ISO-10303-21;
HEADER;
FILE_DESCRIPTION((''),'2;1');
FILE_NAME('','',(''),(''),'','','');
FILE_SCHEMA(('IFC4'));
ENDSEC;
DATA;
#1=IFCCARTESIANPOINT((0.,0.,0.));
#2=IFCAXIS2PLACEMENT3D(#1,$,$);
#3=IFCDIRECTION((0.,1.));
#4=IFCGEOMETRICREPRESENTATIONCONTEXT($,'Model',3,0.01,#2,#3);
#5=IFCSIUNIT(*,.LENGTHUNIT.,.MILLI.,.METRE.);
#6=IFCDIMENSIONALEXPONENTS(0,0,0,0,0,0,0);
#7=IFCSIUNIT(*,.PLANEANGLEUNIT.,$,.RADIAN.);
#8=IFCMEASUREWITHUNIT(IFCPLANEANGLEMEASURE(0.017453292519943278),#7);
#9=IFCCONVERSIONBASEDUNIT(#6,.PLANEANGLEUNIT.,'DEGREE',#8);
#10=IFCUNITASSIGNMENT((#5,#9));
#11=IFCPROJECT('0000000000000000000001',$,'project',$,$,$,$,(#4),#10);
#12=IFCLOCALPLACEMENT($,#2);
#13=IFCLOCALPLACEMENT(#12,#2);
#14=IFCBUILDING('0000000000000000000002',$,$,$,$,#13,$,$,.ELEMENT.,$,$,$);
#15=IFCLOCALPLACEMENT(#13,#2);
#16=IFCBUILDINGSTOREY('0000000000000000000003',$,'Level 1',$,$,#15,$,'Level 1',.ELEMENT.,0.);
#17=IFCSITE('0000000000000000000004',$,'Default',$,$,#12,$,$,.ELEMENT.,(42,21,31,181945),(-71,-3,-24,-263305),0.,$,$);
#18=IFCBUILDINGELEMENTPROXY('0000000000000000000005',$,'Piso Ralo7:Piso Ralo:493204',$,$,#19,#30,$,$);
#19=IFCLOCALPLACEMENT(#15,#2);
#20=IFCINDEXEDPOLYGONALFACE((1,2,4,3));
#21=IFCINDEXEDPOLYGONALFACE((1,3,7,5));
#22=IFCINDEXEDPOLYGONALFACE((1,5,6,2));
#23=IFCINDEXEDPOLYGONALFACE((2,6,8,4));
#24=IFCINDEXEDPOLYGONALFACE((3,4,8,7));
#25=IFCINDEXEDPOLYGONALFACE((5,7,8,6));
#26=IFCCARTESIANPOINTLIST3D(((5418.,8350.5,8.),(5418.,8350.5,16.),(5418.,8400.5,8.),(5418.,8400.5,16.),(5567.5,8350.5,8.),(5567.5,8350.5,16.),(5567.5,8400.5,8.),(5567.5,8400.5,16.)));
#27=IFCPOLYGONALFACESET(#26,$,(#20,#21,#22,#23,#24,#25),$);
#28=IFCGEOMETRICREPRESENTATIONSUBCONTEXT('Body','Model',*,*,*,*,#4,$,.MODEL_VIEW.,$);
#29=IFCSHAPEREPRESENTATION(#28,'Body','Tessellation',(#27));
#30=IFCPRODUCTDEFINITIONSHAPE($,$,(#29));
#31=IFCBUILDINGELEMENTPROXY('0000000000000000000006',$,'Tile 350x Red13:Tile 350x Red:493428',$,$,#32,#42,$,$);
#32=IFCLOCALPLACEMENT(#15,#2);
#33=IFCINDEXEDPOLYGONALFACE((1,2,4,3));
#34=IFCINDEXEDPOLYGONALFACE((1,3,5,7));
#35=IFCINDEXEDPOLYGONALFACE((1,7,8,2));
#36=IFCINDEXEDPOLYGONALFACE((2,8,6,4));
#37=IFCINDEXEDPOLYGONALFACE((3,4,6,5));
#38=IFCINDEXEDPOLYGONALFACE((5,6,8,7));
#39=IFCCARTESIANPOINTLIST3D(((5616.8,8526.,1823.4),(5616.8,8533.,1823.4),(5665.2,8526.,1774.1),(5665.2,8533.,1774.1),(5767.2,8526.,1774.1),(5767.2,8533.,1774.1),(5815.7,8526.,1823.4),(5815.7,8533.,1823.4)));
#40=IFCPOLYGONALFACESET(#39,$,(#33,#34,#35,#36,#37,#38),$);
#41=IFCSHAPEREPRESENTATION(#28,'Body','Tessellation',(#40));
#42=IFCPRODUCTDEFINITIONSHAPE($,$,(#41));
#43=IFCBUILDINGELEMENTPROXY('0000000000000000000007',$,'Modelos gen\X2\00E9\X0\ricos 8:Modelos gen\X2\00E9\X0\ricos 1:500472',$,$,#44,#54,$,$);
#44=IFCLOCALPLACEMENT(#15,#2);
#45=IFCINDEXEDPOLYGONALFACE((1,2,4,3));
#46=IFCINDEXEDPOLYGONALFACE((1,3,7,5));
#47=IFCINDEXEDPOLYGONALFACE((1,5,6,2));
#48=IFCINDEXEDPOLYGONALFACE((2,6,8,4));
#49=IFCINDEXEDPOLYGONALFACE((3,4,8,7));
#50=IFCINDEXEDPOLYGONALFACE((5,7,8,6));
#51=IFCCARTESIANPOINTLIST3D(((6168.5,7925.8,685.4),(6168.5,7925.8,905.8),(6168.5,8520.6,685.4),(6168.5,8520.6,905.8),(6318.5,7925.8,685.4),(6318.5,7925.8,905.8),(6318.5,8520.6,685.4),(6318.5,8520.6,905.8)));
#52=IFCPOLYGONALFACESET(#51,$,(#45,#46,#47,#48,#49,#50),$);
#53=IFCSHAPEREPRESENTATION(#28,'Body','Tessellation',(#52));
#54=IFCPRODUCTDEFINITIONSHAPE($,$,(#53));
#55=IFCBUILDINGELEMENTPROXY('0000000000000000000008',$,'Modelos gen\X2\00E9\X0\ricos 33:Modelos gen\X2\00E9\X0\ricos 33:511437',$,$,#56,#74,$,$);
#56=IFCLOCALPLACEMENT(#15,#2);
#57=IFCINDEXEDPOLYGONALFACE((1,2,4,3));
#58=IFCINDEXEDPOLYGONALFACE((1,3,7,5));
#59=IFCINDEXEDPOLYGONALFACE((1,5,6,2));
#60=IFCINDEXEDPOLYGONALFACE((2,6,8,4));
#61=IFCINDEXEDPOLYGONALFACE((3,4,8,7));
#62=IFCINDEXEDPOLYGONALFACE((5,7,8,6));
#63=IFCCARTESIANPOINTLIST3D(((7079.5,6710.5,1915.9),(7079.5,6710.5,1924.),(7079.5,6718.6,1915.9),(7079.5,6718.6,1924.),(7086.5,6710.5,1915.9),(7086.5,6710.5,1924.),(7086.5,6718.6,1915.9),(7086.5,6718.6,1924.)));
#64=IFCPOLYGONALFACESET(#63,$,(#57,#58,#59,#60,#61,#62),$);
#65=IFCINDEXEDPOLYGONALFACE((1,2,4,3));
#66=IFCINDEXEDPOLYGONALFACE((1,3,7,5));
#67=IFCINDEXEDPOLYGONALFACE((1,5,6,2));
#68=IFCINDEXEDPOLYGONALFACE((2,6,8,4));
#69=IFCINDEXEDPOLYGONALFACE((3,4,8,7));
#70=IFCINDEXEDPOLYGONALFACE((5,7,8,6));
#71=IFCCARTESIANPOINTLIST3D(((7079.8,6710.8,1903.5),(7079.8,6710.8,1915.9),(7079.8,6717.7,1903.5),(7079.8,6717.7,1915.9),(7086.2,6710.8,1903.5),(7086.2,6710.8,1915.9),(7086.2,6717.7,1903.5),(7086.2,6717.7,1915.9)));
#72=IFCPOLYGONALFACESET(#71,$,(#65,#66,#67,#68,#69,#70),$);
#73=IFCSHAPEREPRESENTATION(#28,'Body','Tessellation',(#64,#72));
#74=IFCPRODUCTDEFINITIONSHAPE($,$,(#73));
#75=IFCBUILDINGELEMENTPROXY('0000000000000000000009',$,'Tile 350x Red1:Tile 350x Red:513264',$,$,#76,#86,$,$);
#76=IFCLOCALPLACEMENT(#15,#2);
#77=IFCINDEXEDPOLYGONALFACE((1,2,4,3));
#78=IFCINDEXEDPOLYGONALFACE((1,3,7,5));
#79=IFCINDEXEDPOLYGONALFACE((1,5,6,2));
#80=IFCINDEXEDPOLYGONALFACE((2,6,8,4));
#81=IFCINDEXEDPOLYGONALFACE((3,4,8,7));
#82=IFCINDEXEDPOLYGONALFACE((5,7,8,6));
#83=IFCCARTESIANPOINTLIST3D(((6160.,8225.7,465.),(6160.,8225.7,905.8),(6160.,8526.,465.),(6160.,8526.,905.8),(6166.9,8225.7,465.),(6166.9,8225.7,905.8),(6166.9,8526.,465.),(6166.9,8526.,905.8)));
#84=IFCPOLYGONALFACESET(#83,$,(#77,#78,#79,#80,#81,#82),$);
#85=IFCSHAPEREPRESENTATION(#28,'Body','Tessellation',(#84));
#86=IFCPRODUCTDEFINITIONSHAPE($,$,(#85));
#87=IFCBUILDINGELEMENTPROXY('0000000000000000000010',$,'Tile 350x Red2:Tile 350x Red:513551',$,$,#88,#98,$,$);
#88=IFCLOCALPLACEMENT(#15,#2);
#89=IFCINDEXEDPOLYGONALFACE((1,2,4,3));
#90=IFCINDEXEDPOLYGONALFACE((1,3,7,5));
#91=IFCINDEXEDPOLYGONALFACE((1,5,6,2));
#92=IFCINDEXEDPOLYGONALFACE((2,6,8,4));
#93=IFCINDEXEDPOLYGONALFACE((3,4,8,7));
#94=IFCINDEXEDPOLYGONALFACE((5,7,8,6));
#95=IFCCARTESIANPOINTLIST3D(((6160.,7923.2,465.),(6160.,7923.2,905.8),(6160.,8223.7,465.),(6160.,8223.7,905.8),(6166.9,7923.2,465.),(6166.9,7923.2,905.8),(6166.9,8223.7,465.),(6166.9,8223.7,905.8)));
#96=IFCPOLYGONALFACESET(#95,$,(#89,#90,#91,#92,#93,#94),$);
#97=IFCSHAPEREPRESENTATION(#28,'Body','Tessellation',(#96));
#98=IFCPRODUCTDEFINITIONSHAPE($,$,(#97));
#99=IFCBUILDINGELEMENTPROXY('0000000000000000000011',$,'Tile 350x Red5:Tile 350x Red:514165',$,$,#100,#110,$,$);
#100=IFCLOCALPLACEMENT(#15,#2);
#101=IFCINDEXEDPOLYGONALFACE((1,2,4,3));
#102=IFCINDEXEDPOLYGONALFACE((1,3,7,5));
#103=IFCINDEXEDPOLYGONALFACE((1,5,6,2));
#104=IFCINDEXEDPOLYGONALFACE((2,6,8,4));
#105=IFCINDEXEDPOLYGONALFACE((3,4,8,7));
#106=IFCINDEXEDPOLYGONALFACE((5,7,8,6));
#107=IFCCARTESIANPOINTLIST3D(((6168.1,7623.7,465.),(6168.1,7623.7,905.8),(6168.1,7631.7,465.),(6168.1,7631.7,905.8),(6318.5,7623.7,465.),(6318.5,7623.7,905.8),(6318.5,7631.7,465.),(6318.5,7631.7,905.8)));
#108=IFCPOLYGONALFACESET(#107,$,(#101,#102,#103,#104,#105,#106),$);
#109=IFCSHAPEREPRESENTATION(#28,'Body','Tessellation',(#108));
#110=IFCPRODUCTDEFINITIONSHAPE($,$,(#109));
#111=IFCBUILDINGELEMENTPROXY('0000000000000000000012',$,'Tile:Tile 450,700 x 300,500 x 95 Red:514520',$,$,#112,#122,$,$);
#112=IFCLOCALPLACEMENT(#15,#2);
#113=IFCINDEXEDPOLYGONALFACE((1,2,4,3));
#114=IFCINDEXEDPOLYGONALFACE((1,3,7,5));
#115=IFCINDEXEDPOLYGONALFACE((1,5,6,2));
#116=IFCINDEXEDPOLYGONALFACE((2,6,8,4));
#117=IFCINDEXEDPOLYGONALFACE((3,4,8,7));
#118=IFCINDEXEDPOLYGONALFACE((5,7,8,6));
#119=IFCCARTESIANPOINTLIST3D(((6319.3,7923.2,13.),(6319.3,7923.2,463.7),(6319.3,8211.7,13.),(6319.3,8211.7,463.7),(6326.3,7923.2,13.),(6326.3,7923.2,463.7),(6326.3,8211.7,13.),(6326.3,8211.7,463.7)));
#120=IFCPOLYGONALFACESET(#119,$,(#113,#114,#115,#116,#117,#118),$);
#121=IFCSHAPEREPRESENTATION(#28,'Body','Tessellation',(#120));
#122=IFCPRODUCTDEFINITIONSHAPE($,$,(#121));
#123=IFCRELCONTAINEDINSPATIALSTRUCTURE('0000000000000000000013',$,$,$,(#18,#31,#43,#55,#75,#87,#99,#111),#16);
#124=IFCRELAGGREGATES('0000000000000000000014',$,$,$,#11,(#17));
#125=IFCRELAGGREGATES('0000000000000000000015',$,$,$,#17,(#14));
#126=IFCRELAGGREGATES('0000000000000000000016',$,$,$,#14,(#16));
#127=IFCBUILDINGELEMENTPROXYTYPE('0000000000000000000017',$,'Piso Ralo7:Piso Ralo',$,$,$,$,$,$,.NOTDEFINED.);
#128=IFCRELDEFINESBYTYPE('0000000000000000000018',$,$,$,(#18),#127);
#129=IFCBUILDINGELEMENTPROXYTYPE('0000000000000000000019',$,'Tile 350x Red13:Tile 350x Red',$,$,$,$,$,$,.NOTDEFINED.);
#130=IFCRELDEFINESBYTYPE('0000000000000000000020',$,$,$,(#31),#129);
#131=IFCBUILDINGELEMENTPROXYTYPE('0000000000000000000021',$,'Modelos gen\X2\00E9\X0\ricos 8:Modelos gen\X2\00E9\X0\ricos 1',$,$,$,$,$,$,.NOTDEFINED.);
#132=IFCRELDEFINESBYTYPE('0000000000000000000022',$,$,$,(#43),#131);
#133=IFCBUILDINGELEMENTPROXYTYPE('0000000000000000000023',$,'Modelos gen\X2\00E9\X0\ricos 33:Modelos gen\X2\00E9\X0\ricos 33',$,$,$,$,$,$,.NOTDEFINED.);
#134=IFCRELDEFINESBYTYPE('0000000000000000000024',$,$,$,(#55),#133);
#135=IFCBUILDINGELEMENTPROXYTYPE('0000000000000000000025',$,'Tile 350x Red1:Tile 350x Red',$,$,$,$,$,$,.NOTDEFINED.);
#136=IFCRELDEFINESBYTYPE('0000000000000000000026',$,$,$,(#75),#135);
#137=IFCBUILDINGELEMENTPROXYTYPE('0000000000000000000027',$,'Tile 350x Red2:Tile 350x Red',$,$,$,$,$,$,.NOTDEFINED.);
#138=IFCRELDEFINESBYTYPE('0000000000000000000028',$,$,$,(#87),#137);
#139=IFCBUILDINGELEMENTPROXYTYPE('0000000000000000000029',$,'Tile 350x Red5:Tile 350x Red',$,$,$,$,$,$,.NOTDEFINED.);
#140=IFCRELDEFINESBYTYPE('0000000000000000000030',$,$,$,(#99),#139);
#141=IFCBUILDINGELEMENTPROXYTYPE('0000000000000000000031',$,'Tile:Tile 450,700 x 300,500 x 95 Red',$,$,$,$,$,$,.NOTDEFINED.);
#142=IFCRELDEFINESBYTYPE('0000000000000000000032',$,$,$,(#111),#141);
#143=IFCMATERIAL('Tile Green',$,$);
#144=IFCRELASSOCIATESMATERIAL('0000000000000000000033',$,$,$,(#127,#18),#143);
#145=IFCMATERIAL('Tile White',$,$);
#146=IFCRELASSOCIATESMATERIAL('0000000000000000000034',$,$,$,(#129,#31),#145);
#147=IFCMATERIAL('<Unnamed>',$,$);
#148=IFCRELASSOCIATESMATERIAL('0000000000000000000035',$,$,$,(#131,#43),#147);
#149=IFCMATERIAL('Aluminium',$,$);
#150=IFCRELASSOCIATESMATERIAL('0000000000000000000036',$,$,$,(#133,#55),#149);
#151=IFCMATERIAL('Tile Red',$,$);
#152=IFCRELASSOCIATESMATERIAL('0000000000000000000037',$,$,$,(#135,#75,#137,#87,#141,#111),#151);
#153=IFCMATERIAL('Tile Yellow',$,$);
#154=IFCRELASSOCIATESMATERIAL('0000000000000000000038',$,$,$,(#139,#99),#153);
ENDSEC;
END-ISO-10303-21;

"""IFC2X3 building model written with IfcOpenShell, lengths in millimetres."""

from ifc_helpers import new_model, entity, si_unit, converted_unit, direction, frame, frame_2d, origin, origin_2d_with_axis, place, context, subcontext, project, spatial, polyline, rectangle, outline, extrude, source, transform, mapped, material, type_object, type_shapes, element, save


model = new_model("IFC2X3")

# Units and contexts
model_context = context("Model", 3, precision=0.01, world=origin(), true_north=direction((0.0, 1.0)))
body_context = subcontext(model_context, "Body", "Model", "MODEL_VIEW")
ifc_project = project(units=[si_unit("LENGTHUNIT", "METRE", prefix="MILLI"), converted_unit("PLANEANGLEUNIT", "DEGREE", entity("IfcPlaneAngleMeasure", 0.017453292519943278), si_unit("PLANEANGLEUNIT", "RADIAN"), dimensions=[0, 0, 0, 0, 0, 0, 0])], contexts=[model_context])

# Site, building, storey
site_placement = place(None, origin())
site = spatial("IfcSite", under=ifc_project, at=site_placement, Name="Default", CompositionType="ELEMENT", RefLatitude=(42, 21, 31, 181945), RefLongitude=(-71, -3, -24, -263305), RefElevation=0.0)
building_placement = place(site_placement, origin())
building = spatial("IfcBuilding", under=site, at=building_placement, CompositionType="ELEMENT")
storey_placement = place(building_placement, origin())
storey = spatial("IfcBuildingStorey", under=building, at=storey_placement, Name="Level 1", LongName="Level 1", CompositionType="ELEMENT", Elevation=0.0)

# Building element proxies
ifc_material_1 = material(Name="Tile Green")
building_element_proxy_type_1 = type_object("IfcBuildingElementProxyType", Name="Piso Ralo7:Piso Ralo", PredefinedType="NOTDEFINED", material=ifc_material_1)
shared_shape_1 = source(origin(), body_context, "Body", "SweptSolid", [
    extrude(rectangle(XDim=149.5, YDim=50.0, at=frame_2d((0.0, 0.0), x_axis=(1.0, 0.0))), frame((5492.7, 8375.5, 8.0), z_axis=(0.0, 0.0, 1.0), x_axis=(-1.0, 0.0, 0.0)), (0.0, 0.0, 1.0), 8.0),
])
type_shapes(building_element_proxy_type_1, [shared_shape_1])
proxy_1_placement = place(storey_placement, origin())
element("IfcBuildingElementProxy", 1, at=proxy_1_placement, inside=storey, type_object=building_element_proxy_type_1, material=ifc_material_1, Name="Piso Ralo7:Piso Ralo:493204", context=body_context, shape_type="MappedRepresentation", body=[
    mapped(shared_shape_1, transform((0.0, 0.0, 0.0), scale=1.0)),
])
ifc_material_2 = material(Name="Tile Red")
ifc_material_3 = material(Name="Tile White")
building_element_proxy_type_2 = type_object("IfcBuildingElementProxyType", Name="Tile 350x Red13:Tile 350x Red", PredefinedType="NOTDEFINED", material=ifc_material_3)
shared_shape_2 = source(origin(), body_context, "Body", "SweptSolid", [
    extrude(outline(polyline([(-99.4, -24.7), (99.4, -24.7), (51.0, 24.7), (-51.0, 24.7), (-99.4, -24.7)])), frame((5716.2, 8526.0, 1798.7), z_axis=(0.0, 1.0, 0.0), x_axis=(1.0, 0.0, 0.0)), (0.0, 0.0, 1.0), 7.0),
])
type_shapes(building_element_proxy_type_2, [shared_shape_2])
proxy_2_placement = place(storey_placement, origin())
element("IfcBuildingElementProxy", 2, at=proxy_2_placement, inside=storey, type_object=building_element_proxy_type_2, material=ifc_material_3, Name="Tile 350x Red13:Tile 350x Red:493428", context=body_context, shape_type="MappedRepresentation", body=[
    mapped(shared_shape_2, transform((0.0, 0.0, 0.0), scale=1.0)),
])
ifc_material_4 = material(Name="<Unnamed>")
building_element_proxy_type_3 = type_object("IfcBuildingElementProxyType", Name="Modelos genéricos 8:Modelos genéricos 1", PredefinedType="NOTDEFINED", material=ifc_material_4)
shared_shape_3 = source(origin(), body_context, "Body", "SweptSolid", [
    extrude(rectangle(XDim=594.8, YDim=150.0, at=origin_2d_with_axis()), frame((6243.5, 8223.2, 685.4), z_axis=(0.0, 0.0, 1.0), x_axis=(0.0, 1.0, 0.0)), (0.0, 0.0, 1.0), 220.4),
])
type_shapes(building_element_proxy_type_3, [shared_shape_3])
proxy_3_placement = place(storey_placement, origin())
element("IfcBuildingElementProxy", 3, at=proxy_3_placement, inside=storey, type_object=building_element_proxy_type_3, material=ifc_material_4, Name="Modelos genéricos 8:Modelos genéricos 1:500472", context=body_context, shape_type="MappedRepresentation", body=[
    mapped(shared_shape_3, transform((0.0, 0.0, 0.0), scale=1.0)),
])
ifc_material_5 = material(Name="Aluminium")
building_element_proxy_type_4 = type_object("IfcBuildingElementProxyType", Name="Modelos genéricos 33:Modelos genéricos 33", PredefinedType="NOTDEFINED", material=ifc_material_5)
shared_shape_4 = source(origin(), body_context, "Body", "SweptSolid", [
    extrude(rectangle(XDim=8.2, YDim=7.0, at=frame_2d((0.0, 0.0), x_axis=(1.0, 0.0))), frame((7083.0, 6714.5, 1915.9), z_axis=(0.0, 0.0, 1.0), x_axis=(0.0, 1.0, 0.0)), (0.0, 0.0, 1.0), 8.1),
    extrude(rectangle(XDim=6.9, YDim=6.4, at=frame_2d((0.0, 0.0), x_axis=(1.0, 0.0))), frame((7083.0, 6714.2, 1903.5), z_axis=(0.0, 0.0, 1.0), x_axis=(0.0, 1.0, 0.0)), (0.0, 0.0, 1.0), 12.3),
])
type_shapes(building_element_proxy_type_4, [shared_shape_4])
proxy_4_placement = place(storey_placement, origin())
element("IfcBuildingElementProxy", 4, at=proxy_4_placement, inside=storey, type_object=building_element_proxy_type_4, material=ifc_material_5, Name="Modelos genéricos 33:Modelos genéricos 33:511437", context=body_context, shape_type="MappedRepresentation", body=[
    mapped(shared_shape_4, transform((0.0, 0.0, 0.0), scale=1.0)),
])
building_element_proxy_type_5 = type_object("IfcBuildingElementProxyType", Name="Tile 350x Red1:Tile 350x Red", PredefinedType="NOTDEFINED", material=ifc_material_2)
shared_shape_5 = source(origin(), body_context, "Body", "SweptSolid", [
    extrude(rectangle(XDim=6.9, YDim=300.3, at=frame_2d((0.0, 0.0), x_axis=(1.0, 0.0))), frame((6163.4, 8375.9, 465.0), z_axis=(0.0, 0.0, 1.0), x_axis=(-1.0, 0.0, 0.0)), (0.0, 0.0, 1.0), 440.8),
])
type_shapes(building_element_proxy_type_5, [shared_shape_5])
proxy_5_placement = place(storey_placement, origin())
element("IfcBuildingElementProxy", 5, at=proxy_5_placement, inside=storey, type_object=building_element_proxy_type_5, material=ifc_material_2, Name="Tile 350x Red1:Tile 350x Red:513264", context=body_context, shape_type="MappedRepresentation", body=[
    mapped(shared_shape_5, transform((0.0, 0.0, 0.0), scale=1.0)),
])
building_element_proxy_type_6 = type_object("IfcBuildingElementProxyType", Name="Tile 350x Red2:Tile 350x Red", PredefinedType="NOTDEFINED", material=ifc_material_2)
shared_shape_6 = source(origin(), body_context, "Body", "SweptSolid", [
    extrude(rectangle(XDim=6.9, YDim=300.5, at=frame_2d((0.0, 0.0), x_axis=(1.0, 0.0))), frame((6163.4, 8073.4, 465.0), z_axis=(0.0, 0.0, 1.0), x_axis=(-1.0, 0.0, 0.0)), (0.0, 0.0, 1.0), 440.8),
])
type_shapes(building_element_proxy_type_6, [shared_shape_6])
proxy_6_placement = place(storey_placement, origin())
element("IfcBuildingElementProxy", 6, at=proxy_6_placement, inside=storey, type_object=building_element_proxy_type_6, material=ifc_material_2, Name="Tile 350x Red2:Tile 350x Red:513551", context=body_context, shape_type="MappedRepresentation", body=[
    mapped(shared_shape_6, transform((0.0, 0.0, 0.0), scale=1.0)),
])
ifc_material_6 = material(Name="Tile Yellow")
building_element_proxy_type_7 = type_object("IfcBuildingElementProxyType", Name="Tile 350x Red5:Tile 350x Red", PredefinedType="NOTDEFINED", material=ifc_material_6)
shared_shape_7 = source(origin(), body_context, "Body", "SweptSolid", [
    extrude(rectangle(XDim=8.0, YDim=150.5, at=frame_2d((0.0, 0.0), x_axis=(1.0, 0.0))), frame((6243.3, 7627.7, 465.0), z_axis=(0.0, 0.0, 1.0), x_axis=(0.0, -1.0, 0.0)), (0.0, 0.0, 1.0), 440.8),
])
type_shapes(building_element_proxy_type_7, [shared_shape_7])
proxy_7_placement = place(storey_placement, origin())
element("IfcBuildingElementProxy", 7, at=proxy_7_placement, inside=storey, type_object=building_element_proxy_type_7, material=ifc_material_6, Name="Tile 350x Red5:Tile 350x Red:514165", context=body_context, shape_type="MappedRepresentation", body=[
    mapped(shared_shape_7, transform((0.0, 0.0, 0.0), scale=1.0)),
])
building_element_proxy_type_8 = type_object("IfcBuildingElementProxyType", Name="Tile:Tile 450,700 x 300,500 x 95 Red", PredefinedType="NOTDEFINED", material=ifc_material_2)
shared_shape_8 = source(origin(), body_context, "Body", "SweptSolid", [
    extrude(rectangle(XDim=288.5, YDim=7.0, at=frame_2d((0.0, 0.0), x_axis=(1.0, 0.0))), frame((6322.8, 8067.4, 13.0), z_axis=(0.0, 0.0, 1.0), x_axis=(0.0, 1.0, 0.0)), (0.0, 0.0, 1.0), 450.7),
])
type_shapes(building_element_proxy_type_8, [shared_shape_8])
proxy_8_placement = place(storey_placement, origin())
element("IfcBuildingElementProxy", 8, at=proxy_8_placement, inside=storey, type_object=building_element_proxy_type_8, material=ifc_material_2, Name="Tile:Tile 450,700 x 300,500 x 95 Red:514520", context=body_context, shape_type="MappedRepresentation", body=[
    mapped(shared_shape_8, transform((0.0, 0.0, 0.0), scale=1.0)),
])

save(model, "model.ifc")
